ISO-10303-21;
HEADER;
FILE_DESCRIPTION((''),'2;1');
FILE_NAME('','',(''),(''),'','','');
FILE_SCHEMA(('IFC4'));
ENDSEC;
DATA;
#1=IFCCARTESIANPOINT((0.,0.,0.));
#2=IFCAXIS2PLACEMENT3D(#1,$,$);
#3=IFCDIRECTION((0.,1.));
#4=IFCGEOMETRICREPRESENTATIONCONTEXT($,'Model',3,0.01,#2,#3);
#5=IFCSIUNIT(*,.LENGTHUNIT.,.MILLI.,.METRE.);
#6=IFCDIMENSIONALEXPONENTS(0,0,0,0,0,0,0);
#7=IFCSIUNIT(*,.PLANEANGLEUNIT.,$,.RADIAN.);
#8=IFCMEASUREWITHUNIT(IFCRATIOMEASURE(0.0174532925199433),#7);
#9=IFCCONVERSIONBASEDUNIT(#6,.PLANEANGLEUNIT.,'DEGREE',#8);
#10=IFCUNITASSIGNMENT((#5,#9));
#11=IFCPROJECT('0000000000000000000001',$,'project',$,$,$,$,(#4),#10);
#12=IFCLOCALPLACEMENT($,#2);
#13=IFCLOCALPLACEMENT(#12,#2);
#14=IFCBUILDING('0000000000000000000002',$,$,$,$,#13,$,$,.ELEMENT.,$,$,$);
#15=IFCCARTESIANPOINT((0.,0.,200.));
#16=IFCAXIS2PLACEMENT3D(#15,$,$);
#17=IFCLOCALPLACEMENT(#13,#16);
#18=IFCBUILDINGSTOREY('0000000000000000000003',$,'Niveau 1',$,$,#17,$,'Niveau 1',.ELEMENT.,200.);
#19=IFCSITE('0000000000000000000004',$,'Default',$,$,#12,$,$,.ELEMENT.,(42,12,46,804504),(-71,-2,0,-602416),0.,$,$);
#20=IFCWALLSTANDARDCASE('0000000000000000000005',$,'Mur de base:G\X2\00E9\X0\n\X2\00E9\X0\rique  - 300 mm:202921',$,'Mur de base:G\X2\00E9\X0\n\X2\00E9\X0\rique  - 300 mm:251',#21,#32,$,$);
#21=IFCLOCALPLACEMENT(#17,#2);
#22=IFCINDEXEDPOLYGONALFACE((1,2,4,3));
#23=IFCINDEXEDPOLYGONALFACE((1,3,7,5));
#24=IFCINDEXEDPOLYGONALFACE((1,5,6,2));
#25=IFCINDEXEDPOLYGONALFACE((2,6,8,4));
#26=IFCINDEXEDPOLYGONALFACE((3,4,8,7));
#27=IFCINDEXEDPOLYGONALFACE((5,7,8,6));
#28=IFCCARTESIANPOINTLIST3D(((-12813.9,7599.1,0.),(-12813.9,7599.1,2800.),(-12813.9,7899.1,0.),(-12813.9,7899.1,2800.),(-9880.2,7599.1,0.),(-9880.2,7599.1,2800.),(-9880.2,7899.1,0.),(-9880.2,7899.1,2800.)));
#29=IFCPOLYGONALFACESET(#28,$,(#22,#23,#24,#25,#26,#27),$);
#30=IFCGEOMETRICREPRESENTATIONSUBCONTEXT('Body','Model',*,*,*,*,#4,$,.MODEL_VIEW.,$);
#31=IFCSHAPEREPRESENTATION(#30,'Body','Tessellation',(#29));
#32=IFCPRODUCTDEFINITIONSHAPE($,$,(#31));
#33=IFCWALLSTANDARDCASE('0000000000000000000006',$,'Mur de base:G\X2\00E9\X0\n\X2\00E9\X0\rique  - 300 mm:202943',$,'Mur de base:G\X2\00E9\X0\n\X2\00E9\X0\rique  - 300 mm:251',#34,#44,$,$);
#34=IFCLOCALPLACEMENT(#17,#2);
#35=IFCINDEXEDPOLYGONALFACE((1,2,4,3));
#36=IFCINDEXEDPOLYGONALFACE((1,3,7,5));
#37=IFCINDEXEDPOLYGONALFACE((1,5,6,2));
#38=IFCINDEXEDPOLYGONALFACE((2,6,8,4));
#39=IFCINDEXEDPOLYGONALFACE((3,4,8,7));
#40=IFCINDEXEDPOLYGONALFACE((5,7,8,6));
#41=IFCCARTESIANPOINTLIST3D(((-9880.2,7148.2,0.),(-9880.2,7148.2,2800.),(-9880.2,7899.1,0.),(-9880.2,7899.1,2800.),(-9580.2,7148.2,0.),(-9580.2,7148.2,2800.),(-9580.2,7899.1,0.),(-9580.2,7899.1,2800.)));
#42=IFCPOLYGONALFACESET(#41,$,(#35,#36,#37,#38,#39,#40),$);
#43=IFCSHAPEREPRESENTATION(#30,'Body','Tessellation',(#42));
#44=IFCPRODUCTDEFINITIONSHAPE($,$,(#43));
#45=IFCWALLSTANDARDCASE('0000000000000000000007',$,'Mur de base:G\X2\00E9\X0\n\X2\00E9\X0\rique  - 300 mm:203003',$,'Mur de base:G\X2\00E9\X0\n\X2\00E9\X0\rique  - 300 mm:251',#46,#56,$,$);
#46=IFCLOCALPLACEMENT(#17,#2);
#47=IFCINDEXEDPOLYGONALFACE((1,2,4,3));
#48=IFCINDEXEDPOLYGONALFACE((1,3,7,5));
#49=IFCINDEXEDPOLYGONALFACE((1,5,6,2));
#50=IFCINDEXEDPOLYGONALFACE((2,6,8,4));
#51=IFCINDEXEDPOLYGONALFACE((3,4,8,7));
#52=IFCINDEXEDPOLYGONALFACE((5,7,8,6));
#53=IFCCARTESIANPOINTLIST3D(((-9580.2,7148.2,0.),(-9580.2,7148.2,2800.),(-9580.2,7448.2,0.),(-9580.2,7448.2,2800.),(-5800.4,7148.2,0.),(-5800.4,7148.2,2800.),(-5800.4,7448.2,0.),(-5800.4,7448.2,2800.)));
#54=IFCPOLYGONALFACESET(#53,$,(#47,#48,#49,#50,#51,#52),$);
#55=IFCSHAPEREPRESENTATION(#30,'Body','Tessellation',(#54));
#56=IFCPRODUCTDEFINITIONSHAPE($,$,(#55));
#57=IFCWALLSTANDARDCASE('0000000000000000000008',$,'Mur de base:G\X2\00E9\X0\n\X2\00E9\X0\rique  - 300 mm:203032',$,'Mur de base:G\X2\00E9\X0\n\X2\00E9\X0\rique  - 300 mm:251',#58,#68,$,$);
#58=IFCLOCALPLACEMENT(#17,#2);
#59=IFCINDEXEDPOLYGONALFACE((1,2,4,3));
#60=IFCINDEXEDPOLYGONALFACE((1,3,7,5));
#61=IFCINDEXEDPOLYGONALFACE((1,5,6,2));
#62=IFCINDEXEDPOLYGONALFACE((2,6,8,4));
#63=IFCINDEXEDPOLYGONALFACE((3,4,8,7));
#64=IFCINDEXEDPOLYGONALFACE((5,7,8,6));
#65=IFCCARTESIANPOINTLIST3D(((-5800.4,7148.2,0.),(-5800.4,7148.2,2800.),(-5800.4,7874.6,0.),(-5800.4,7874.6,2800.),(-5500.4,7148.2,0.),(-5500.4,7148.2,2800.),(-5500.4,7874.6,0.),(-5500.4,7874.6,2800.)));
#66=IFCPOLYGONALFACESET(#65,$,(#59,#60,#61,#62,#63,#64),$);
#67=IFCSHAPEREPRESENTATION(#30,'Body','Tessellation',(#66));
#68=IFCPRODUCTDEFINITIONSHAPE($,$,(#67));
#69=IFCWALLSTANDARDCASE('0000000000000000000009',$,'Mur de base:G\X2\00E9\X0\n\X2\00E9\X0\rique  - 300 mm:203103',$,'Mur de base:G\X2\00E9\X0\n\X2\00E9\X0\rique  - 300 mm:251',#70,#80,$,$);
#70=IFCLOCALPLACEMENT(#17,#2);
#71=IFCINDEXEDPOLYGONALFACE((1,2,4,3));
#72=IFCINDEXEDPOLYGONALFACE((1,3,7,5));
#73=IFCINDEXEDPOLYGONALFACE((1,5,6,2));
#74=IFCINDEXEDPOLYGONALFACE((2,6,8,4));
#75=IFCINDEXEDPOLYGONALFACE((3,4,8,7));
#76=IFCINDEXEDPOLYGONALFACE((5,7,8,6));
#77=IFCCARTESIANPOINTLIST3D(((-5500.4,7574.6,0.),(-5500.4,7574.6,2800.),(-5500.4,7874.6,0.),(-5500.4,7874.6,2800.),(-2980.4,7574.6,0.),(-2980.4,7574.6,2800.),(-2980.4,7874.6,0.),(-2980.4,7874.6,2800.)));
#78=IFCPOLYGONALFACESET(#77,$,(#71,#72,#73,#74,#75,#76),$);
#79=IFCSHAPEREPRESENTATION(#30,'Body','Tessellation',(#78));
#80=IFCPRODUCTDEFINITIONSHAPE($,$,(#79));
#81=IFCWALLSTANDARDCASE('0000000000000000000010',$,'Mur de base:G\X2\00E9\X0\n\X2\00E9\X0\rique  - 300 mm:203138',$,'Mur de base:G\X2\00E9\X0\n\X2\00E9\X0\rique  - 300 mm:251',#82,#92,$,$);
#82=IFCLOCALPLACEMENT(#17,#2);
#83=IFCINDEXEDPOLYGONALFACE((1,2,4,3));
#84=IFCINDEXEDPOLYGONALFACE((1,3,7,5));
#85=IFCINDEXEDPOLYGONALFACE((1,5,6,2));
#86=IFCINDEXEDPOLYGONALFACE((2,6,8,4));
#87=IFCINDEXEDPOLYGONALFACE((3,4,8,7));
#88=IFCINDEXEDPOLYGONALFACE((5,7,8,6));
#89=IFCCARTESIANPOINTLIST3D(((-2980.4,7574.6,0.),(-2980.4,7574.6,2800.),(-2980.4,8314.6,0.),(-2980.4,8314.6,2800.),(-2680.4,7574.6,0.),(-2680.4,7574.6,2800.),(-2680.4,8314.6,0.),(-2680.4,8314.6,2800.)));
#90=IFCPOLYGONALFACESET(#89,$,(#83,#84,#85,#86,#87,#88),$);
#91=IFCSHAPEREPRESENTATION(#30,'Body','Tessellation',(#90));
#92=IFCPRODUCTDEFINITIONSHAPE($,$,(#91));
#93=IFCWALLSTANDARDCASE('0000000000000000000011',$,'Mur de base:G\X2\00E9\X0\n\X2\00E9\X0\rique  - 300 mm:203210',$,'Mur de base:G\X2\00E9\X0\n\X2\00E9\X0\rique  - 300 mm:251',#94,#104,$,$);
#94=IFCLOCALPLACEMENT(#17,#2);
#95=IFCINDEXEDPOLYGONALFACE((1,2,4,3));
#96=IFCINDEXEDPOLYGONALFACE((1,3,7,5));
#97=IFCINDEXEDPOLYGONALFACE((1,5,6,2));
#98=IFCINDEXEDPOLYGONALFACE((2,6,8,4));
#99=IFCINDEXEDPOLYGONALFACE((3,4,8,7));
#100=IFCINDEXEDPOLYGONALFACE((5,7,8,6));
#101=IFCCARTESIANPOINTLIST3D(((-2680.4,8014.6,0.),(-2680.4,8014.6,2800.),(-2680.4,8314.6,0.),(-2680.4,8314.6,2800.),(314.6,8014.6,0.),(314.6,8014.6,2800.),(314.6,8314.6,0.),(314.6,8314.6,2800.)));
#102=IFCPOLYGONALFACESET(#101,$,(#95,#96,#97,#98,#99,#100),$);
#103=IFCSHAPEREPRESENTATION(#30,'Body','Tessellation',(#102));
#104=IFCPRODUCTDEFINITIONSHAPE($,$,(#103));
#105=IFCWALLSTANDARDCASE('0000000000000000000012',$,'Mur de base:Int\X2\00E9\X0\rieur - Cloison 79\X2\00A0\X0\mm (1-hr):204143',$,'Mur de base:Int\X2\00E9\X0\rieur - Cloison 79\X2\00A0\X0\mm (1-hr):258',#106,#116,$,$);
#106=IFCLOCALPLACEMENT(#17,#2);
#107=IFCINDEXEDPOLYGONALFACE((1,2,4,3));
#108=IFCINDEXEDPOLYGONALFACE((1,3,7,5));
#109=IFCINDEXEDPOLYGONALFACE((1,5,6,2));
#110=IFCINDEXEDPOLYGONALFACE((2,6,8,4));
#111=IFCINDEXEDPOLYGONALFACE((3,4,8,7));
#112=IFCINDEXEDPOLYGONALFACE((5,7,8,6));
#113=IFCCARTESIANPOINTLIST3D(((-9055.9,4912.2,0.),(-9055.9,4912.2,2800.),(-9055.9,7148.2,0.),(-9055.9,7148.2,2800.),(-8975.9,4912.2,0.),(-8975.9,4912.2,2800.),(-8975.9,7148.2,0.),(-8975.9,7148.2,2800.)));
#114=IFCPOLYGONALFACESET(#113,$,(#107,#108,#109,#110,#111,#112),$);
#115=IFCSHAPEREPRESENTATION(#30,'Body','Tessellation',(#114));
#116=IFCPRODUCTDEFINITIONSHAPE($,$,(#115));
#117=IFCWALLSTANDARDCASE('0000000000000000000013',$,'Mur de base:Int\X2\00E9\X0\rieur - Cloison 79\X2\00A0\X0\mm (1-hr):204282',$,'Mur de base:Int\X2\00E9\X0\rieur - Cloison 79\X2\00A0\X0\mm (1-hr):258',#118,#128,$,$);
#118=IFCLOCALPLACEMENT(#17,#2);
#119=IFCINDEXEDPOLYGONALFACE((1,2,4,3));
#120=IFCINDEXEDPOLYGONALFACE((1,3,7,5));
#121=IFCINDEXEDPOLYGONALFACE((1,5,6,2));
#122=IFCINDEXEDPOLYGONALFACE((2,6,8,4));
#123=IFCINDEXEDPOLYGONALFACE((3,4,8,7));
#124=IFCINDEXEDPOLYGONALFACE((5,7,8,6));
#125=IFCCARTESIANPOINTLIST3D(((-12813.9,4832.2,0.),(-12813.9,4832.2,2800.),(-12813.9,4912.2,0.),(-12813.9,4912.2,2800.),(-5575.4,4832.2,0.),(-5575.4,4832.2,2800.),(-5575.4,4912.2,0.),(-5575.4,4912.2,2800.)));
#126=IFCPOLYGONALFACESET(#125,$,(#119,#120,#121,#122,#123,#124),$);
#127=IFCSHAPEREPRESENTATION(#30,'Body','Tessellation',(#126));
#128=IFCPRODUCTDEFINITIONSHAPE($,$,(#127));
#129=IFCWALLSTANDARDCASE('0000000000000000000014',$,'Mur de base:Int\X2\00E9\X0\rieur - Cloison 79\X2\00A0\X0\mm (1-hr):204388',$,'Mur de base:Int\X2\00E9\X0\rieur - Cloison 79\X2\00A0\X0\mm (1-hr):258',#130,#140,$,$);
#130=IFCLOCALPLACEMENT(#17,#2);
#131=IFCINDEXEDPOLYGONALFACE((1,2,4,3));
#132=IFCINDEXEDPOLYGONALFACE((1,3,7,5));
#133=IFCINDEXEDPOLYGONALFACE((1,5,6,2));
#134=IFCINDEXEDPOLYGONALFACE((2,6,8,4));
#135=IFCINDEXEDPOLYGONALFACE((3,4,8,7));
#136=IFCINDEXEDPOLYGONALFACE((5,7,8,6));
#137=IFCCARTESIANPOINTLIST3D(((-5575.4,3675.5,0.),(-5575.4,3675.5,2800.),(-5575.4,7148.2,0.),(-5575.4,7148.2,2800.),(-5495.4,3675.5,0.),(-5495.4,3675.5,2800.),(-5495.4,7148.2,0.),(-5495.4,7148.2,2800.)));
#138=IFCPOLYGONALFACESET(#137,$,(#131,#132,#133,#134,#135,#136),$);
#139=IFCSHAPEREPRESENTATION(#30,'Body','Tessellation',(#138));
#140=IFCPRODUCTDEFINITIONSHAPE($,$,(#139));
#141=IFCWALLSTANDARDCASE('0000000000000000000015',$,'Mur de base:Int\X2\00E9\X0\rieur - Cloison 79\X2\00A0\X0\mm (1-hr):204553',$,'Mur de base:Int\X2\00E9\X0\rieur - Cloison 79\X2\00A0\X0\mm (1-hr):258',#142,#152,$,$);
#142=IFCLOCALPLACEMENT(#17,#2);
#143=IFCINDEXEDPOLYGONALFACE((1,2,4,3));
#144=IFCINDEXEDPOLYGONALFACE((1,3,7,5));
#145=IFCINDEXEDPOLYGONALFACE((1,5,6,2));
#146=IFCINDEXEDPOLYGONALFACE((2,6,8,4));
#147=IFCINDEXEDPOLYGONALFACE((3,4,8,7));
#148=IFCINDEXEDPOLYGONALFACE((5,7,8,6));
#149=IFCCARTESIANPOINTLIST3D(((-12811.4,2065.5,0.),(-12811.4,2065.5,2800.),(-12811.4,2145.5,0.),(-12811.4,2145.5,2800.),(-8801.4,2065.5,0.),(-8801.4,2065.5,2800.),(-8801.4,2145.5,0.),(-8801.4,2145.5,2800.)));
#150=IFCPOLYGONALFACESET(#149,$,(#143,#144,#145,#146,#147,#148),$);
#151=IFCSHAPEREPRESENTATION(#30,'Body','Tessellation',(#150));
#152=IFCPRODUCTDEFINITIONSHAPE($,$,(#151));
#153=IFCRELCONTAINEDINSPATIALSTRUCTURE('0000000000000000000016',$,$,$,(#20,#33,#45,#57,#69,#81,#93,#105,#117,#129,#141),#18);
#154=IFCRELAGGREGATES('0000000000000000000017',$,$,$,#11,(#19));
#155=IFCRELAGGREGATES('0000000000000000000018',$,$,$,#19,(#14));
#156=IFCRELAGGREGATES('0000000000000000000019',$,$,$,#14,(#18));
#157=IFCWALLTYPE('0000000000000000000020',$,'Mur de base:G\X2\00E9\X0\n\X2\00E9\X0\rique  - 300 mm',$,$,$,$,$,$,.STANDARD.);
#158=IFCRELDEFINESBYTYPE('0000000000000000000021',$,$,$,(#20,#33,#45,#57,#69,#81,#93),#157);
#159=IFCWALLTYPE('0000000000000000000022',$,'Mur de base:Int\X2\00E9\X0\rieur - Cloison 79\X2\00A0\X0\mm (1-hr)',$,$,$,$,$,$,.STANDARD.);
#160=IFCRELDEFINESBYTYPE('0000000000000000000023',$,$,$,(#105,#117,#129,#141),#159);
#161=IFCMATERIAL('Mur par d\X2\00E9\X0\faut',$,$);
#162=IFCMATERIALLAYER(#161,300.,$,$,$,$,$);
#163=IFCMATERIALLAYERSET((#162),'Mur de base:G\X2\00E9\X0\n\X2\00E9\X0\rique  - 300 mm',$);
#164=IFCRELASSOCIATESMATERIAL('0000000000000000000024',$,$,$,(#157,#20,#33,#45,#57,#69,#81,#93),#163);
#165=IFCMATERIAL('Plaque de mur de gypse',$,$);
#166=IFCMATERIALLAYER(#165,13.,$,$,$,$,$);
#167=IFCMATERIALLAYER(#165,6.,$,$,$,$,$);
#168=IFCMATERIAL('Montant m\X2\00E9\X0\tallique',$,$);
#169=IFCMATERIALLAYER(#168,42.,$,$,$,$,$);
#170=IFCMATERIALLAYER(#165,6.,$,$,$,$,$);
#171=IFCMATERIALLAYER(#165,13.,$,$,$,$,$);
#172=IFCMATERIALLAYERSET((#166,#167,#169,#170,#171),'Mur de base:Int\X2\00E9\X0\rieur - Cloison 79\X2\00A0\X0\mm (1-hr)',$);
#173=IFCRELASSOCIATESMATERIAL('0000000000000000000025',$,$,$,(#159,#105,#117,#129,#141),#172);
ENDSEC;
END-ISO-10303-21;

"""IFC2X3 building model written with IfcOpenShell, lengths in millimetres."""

from ifc_helpers import new_model, entity, si_unit, converted_unit, direction, frame, frame_2d, origin, place, context, subcontext, project, spatial, polyline, rectangle, extrude, clip, bounded_halfspace, material, layer, layer_set, layer_usage, type_object, element, save


model = new_model("IFC2X3")

# Units and contexts
model_context = context("Model", 3, precision=0.01, world=origin(), true_north=direction((0.0, 1.0)))
body_context = subcontext(model_context, "Body", "Model", "MODEL_VIEW")
ifc_project = project(units=[si_unit("LENGTHUNIT", "METRE", prefix="MILLI"), converted_unit("PLANEANGLEUNIT", "DEGREE", entity("IfcRatioMeasure", 0.0174532925199433), si_unit("PLANEANGLEUNIT", "RADIAN"), dimensions=[0, 0, 0, 0, 0, 0, 0])], contexts=[model_context])

# Site, building, storey
site_placement = place(None, origin())
site = spatial("IfcSite", under=ifc_project, at=site_placement, Name="Default", CompositionType="ELEMENT", RefLatitude=(42, 12, 46, 804504), RefLongitude=(-71, -2, 0, -602416), RefElevation=0.0)
building_placement = place(site_placement, origin())
building = spatial("IfcBuilding", under=site, at=building_placement, CompositionType="ELEMENT")
storey_placement = place(building_placement, frame((0.0, 0.0, 200.0)))
storey = spatial("IfcBuildingStorey", under=building, at=storey_placement, Name="Niveau 1", LongName="Niveau 1", CompositionType="ELEMENT", Elevation=200.0)

# Walls
ifc_material_1 = material(Name="Mur par défaut")
ifc_layer_1 = layer(ifc_material_1, 300.0)
ifc_layer_set_1 = layer_set([ifc_layer_1], Name="Mur de base:Générique  - 300 mm")
ifc_layer_usage_1 = layer_usage(ifc_layer_set_1, "AXIS2", "NEGATIVE", 150.0)
wall_type_1 = type_object("IfcWallType", Name="Mur de base:Générique  - 300 mm", PredefinedType="STANDARD", material=ifc_layer_set_1)
wall_1_placement = place(storey_placement, frame((-12813.9, 7749.1, 0.0)))
element("IfcWallStandardCase", 1, at=wall_1_placement, inside=storey, type_object=wall_type_1, material=ifc_layer_usage_1, Name="Mur de base:Générique  - 300 mm:202921", ObjectType="Mur de base:Générique  - 300 mm:251", context=body_context, shape_type="Clipping", body=[
    clip(extrude(rectangle(XDim=2933.8, YDim=300.0, at=frame_2d((1466.9, 0.0), x_axis=(-1.0, 0.0))), origin(), (0.0, 0.0, 1.0), 2800.0), bounded_halfspace(frame((0.0, -150.0, 2800.0), z_axis=(0.0, 0.0, -1.0), x_axis=(0.0, 1.0, 0.0)), True, frame((0.0, -150.0, 2800.0)), polyline([(0.0, 0.0), (2933.8, 0.0), (2933.8, 300.0), (0.0, 300.0), (0.0, 0.0)]))),
])
ifc_layer_usage_2 = layer_usage(ifc_layer_set_1, "AXIS2", "NEGATIVE", 150.0)
wall_2_placement = place(storey_placement, frame((-9730.2, 7899.1, 0.0), z_axis=(0.0, 0.0, 1.0), x_axis=(0.0, -1.0, 0.0)))
element("IfcWallStandardCase", 2, at=wall_2_placement, inside=storey, type_object=wall_type_1, material=ifc_layer_usage_2, Name="Mur de base:Générique  - 300 mm:202943", ObjectType="Mur de base:Générique  - 300 mm:251", context=body_context, shape_type="Clipping", body=[
    clip(extrude(rectangle(XDim=750.9, YDim=300.0, at=frame_2d((375.4, 0.0), x_axis=(-1.0, 0.0))), origin(), (0.0, 0.0, 1.0), 2800.0), bounded_halfspace(frame((0.0, -150.0, 2800.0), z_axis=(0.0, 0.0, -1.0), x_axis=(-1.0, 0.0, 0.0)), True, frame((0.0, -150.0, 2800.0)), polyline([(0.0, 0.0), (300.0, 0.0), (750.9, 0.0), (750.9, 300.0), (450.9, 300.0), (0.0, 300.0), (0.0, 0.0)]))),
])
ifc_layer_usage_3 = layer_usage(ifc_layer_set_1, "AXIS2", "NEGATIVE", 150.0)
wall_3_placement = place(storey_placement, frame((-9580.2, 7298.2, 0.0)))
element("IfcWallStandardCase", 3, at=wall_3_placement, inside=storey, type_object=wall_type_1, material=ifc_layer_usage_3, Name="Mur de base:Générique  - 300 mm:203003", ObjectType="Mur de base:Générique  - 300 mm:251", context=body_context, shape_type="Clipping", body=[
    clip(extrude(rectangle(XDim=3779.8, YDim=300.0, at=frame_2d((1889.9, 0.0), x_axis=(-1.0, 0.0))), origin(), (0.0, 0.0, 1.0), 2800.0), bounded_halfspace(frame((0.0, -150.0, 2800.0), z_axis=(0.0, 0.0, -1.0), x_axis=(0.0, 1.0, 0.0)), True, frame((0.0, -150.0, 2800.0)), polyline([(0.0, 0.0), (524.3, 0.0), (604.3, 0.0), (3779.8, 0.0), (3779.8, 300.0), (0.0, 300.0), (0.0, 0.0)]))),
])
ifc_layer_usage_4 = layer_usage(ifc_layer_set_1, "AXIS2", "NEGATIVE", 150.0)
wall_4_placement = place(storey_placement, frame((-5650.4, 7148.2, 0.0), z_axis=(0.0, 0.0, 1.0), x_axis=(0.0, 1.0, 0.0)))
element("IfcWallStandardCase", 4, at=wall_4_placement, inside=storey, type_object=wall_type_1, material=ifc_layer_usage_4, Name="Mur de base:Générique  - 300 mm:203032", ObjectType="Mur de base:Générique  - 300 mm:251", context=body_context, shape_type="Clipping", body=[
    clip(extrude(rectangle(XDim=726.4, YDim=300.0, at=frame_2d((363.2, 0.0), x_axis=(-1.0, 0.0))), origin(), (0.0, 0.0, 1.0), 2800.0), bounded_halfspace(frame((0.0, -150.0, 2800.0), z_axis=(0.0, 0.0, -1.0), x_axis=(1.0, 0.0, 0.0)), True, frame((0.0, -150.0, 2800.0)), polyline([(0.0, 0.0), (426.4, 0.0), (726.4, 0.0), (726.4, 300.0), (300.0, 300.0), (0.0, 300.0), (0.0, 75.0), (0.0, 0.0)]))),
])
ifc_layer_usage_5 = layer_usage(ifc_layer_set_1, "AXIS2", "NEGATIVE", 150.0)
wall_5_placement = place(storey_placement, frame((-5500.4, 7724.6, 0.0)))
element("IfcWallStandardCase", 5, at=wall_5_placement, inside=storey, type_object=wall_type_1, material=ifc_layer_usage_5, Name="Mur de base:Générique  - 300 mm:203103", ObjectType="Mur de base:Générique  - 300 mm:251", context=body_context, shape_type="Clipping", body=[
    clip(extrude(rectangle(XDim=2520.0, YDim=300.0, at=frame_2d((1260.0, 0.0), x_axis=(-1.0, 0.0))), origin(), (0.0, 0.0, 1.0), 2800.0), bounded_halfspace(frame((0.0, -150.0, 2800.0), z_axis=(0.0, 0.0, -1.0), x_axis=(0.0, 1.0, 0.0)), True, frame((0.0, -150.0, 2800.0)), polyline([(0.0, 0.0), (1602.7, 0.0), (1682.7, 0.0), (2520.0, 0.0), (2520.0, 300.0), (0.0, 300.0), (0.0, 0.0)]))),
])
ifc_layer_usage_6 = layer_usage(ifc_layer_set_1, "AXIS2", "NEGATIVE", 150.0)
wall_6_placement = place(storey_placement, frame((-2830.4, 7574.6, 0.0), z_axis=(0.0, 0.0, 1.0), x_axis=(0.0, 1.0, 0.0)))
element("IfcWallStandardCase", 6, at=wall_6_placement, inside=storey, type_object=wall_type_1, material=ifc_layer_usage_6, Name="Mur de base:Générique  - 300 mm:203138", ObjectType="Mur de base:Générique  - 300 mm:251", context=body_context, shape_type="Clipping", body=[
    clip(extrude(rectangle(XDim=740.0, YDim=300.0, at=frame_2d((370.0, 0.0), x_axis=(-1.0, 0.0))), origin(), (0.0, 0.0, 1.0), 2800.0), bounded_halfspace(frame((0.0, -150.0, 2800.0), z_axis=(0.0, 0.0, -1.0), x_axis=(1.0, 0.0, 0.0)), True, frame((0.0, -150.0, 2800.0)), polyline([(0.0, 0.0), (440.0, 0.0), (740.0, 0.0), (740.0, 300.0), (300.0, 300.0), (0.0, 300.0), (0.0, 0.0)]))),
])
ifc_layer_usage_7 = layer_usage(ifc_layer_set_1, "AXIS2", "NEGATIVE", 150.0)
wall_7_placement = place(storey_placement, frame((-2680.4, 8164.6, 0.0)))
element("IfcWallStandardCase", 7, at=wall_7_placement, inside=storey, type_object=wall_type_1, material=ifc_layer_usage_7, Name="Mur de base:Générique  - 300 mm:203210", ObjectType="Mur de base:Générique  - 300 mm:251", context=body_context, shape_type="Clipping", body=[
    clip(extrude(rectangle(XDim=2995.0, YDim=300.0, at=frame_2d((1497.5, 0.0), x_axis=(-1.0, 0.0))), origin(), (0.0, 0.0, 1.0), 2800.0), bounded_halfspace(frame((0.0, -150.0, 2800.0), z_axis=(0.0, 0.0, -1.0), x_axis=(0.0, 1.0, 0.0)), True, frame((0.0, -150.0, 2800.0)), polyline([(0.0, 0.0), (2695.0, 0.0), (2995.0, 0.0), (2995.0, 300.0), (0.0, 300.0), (0.0, 0.0)]))),
])
ifc_material_2 = material(Name="Plaque de mur de gypse")
ifc_layer_2 = layer(ifc_material_2, 13.0)
ifc_layer_3 = layer(ifc_material_2, 6.0)
ifc_material_3 = material(Name="Montant métallique")
ifc_layer_4 = layer(ifc_material_3, 42.0)
ifc_layer_5 = layer(ifc_material_2, 6.0)
ifc_layer_6 = layer(ifc_material_2, 13.0)
ifc_layer_set_2 = layer_set([ifc_layer_2, ifc_layer_3, ifc_layer_4, ifc_layer_5, ifc_layer_6], Name="Mur de base:Intérieur - Cloison 79 mm (1-hr)")
ifc_layer_usage_8 = layer_usage(ifc_layer_set_2, "AXIS2", "NEGATIVE", 40.0)
wall_type_2 = type_object("IfcWallType", Name="Mur de base:Intérieur - Cloison 79 mm (1-hr)", PredefinedType="STANDARD", material=ifc_layer_set_2)
wall_8_placement = place(storey_placement, frame((-9015.9, 7148.2, 0.0), z_axis=(0.0, 0.0, 1.0), x_axis=(0.0, -1.0, 0.0)))
element("IfcWallStandardCase", 8, at=wall_8_placement, inside=storey, type_object=wall_type_2, material=ifc_layer_usage_8, Name="Mur de base:Intérieur - Cloison 79 mm (1-hr):204143", ObjectType="Mur de base:Intérieur - Cloison 79 mm (1-hr):258", context=body_context, shape_type="Clipping", body=[
    clip(extrude(rectangle(XDim=2236.0, YDim=80.0, at=frame_2d((1118.0, 0.0), x_axis=(-1.0, 0.0))), origin(), (0.0, 0.0, 1.0), 2800.0), bounded_halfspace(frame((0.0, -40.0, 2800.0), z_axis=(0.0, 0.0, -1.0), x_axis=(-1.0, 0.0, 0.0)), True, frame((0.0, -40.0, 2800.0)), polyline([(0.0, 0.0), (2236.0, 0.0), (2236.0, 80.0), (0.0, 80.0), (0.0, 0.0)]))),
])
ifc_layer_usage_9 = layer_usage(ifc_layer_set_2, "AXIS2", "NEGATIVE", 40.0)
wall_9_placement = place(storey_placement, frame((-12813.9, 4872.2, 0.0)))
element("IfcWallStandardCase", 9, at=wall_9_placement, inside=storey, type_object=wall_type_2, material=ifc_layer_usage_9, Name="Mur de base:Intérieur - Cloison 79 mm (1-hr):204282", ObjectType="Mur de base:Intérieur - Cloison 79 mm (1-hr):258", context=body_context, shape_type="Clipping", body=[
    clip(extrude(rectangle(XDim=7238.6, YDim=80.0, at=frame_2d((3619.3, 0.0), x_axis=(-1.0, 0.0))), origin(), (0.0, 0.0, 1.0), 2800.0), bounded_halfspace(frame((0.0, -40.0, 2800.0), z_axis=(0.0, 0.0, -1.0), x_axis=(0.0, 1.0, 0.0)), True, frame((0.0, -40.0, 2800.0)), polyline([(0.0, 0.0), (2885.2, 0.0), (2965.2, 0.0), (7238.6, 0.0), (7238.6, 80.0), (3838.0, 80.0), (3758.0, 80.0), (0.0, 80.0), (0.0, 0.0)]))),
])
ifc_layer_usage_10 = layer_usage(ifc_layer_set_2, "AXIS2", "NEGATIVE", 40.0)
wall_10_placement = place(storey_placement, frame((-5535.4, 7148.2, 0.0), z_axis=(0.0, 0.0, 1.0), x_axis=(0.0, -1.0, 0.0)))
element("IfcWallStandardCase", 10, at=wall_10_placement, inside=storey, type_object=wall_type_2, material=ifc_layer_usage_10, Name="Mur de base:Intérieur - Cloison 79 mm (1-hr):204388", ObjectType="Mur de base:Intérieur - Cloison 79 mm (1-hr):258", context=body_context, shape_type="Clipping", body=[
    clip(extrude(rectangle(XDim=3472.6, YDim=80.0, at=frame_2d((1736.3, 0.0), x_axis=(-1.0, 0.0))), origin(), (0.0, 0.0, 1.0), 2800.0), bounded_halfspace(frame((0.0, -40.0, 2800.0), z_axis=(0.0, 0.0, -1.0), x_axis=(-1.0, 0.0, 0.0)), True, frame((0.0, -40.0, 2800.0)), polyline([(0.0, 0.0), (2236.0, 0.0), (2316.0, 0.0), (3472.6, 0.0), (3472.6, 80.0), (527.6, 80.0), (447.6, 80.0), (0.0, 80.0), (0.0, 75.0), (0.0, 0.0)]))),
])
ifc_layer_usage_11 = layer_usage(ifc_layer_set_2, "AXIS2", "NEGATIVE", 40.0)
wall_11_placement = place(storey_placement, frame((-12811.4, 2105.5, 0.0)))
element("IfcWallStandardCase", 11, at=wall_11_placement, inside=storey, type_object=wall_type_2, material=ifc_layer_usage_11, Name="Mur de base:Intérieur - Cloison 79 mm (1-hr):204553", ObjectType="Mur de base:Intérieur - Cloison 79 mm (1-hr):258", context=body_context, shape_type="Clipping", body=[
    clip(extrude(rectangle(XDim=4010.0, YDim=80.0, at=frame_2d((2005.0, 0.0), x_axis=(-1.0, 0.0))), origin(), (0.0, 0.0, 1.0), 2800.0), bounded_halfspace(frame((0.0, -40.0, 2800.0), z_axis=(0.0, 0.0, -1.0), x_axis=(0.0, 1.0, 0.0)), True, frame((0.0, -40.0, 2800.0)), polyline([(0.0, 0.0), (4010.0, 0.0), (4010.0, 80.0), (2962.7, 80.0), (2882.7, 80.0), (0.0, 80.0), (0.0, 0.0)]))),
])

save(model, "model.ifc")
